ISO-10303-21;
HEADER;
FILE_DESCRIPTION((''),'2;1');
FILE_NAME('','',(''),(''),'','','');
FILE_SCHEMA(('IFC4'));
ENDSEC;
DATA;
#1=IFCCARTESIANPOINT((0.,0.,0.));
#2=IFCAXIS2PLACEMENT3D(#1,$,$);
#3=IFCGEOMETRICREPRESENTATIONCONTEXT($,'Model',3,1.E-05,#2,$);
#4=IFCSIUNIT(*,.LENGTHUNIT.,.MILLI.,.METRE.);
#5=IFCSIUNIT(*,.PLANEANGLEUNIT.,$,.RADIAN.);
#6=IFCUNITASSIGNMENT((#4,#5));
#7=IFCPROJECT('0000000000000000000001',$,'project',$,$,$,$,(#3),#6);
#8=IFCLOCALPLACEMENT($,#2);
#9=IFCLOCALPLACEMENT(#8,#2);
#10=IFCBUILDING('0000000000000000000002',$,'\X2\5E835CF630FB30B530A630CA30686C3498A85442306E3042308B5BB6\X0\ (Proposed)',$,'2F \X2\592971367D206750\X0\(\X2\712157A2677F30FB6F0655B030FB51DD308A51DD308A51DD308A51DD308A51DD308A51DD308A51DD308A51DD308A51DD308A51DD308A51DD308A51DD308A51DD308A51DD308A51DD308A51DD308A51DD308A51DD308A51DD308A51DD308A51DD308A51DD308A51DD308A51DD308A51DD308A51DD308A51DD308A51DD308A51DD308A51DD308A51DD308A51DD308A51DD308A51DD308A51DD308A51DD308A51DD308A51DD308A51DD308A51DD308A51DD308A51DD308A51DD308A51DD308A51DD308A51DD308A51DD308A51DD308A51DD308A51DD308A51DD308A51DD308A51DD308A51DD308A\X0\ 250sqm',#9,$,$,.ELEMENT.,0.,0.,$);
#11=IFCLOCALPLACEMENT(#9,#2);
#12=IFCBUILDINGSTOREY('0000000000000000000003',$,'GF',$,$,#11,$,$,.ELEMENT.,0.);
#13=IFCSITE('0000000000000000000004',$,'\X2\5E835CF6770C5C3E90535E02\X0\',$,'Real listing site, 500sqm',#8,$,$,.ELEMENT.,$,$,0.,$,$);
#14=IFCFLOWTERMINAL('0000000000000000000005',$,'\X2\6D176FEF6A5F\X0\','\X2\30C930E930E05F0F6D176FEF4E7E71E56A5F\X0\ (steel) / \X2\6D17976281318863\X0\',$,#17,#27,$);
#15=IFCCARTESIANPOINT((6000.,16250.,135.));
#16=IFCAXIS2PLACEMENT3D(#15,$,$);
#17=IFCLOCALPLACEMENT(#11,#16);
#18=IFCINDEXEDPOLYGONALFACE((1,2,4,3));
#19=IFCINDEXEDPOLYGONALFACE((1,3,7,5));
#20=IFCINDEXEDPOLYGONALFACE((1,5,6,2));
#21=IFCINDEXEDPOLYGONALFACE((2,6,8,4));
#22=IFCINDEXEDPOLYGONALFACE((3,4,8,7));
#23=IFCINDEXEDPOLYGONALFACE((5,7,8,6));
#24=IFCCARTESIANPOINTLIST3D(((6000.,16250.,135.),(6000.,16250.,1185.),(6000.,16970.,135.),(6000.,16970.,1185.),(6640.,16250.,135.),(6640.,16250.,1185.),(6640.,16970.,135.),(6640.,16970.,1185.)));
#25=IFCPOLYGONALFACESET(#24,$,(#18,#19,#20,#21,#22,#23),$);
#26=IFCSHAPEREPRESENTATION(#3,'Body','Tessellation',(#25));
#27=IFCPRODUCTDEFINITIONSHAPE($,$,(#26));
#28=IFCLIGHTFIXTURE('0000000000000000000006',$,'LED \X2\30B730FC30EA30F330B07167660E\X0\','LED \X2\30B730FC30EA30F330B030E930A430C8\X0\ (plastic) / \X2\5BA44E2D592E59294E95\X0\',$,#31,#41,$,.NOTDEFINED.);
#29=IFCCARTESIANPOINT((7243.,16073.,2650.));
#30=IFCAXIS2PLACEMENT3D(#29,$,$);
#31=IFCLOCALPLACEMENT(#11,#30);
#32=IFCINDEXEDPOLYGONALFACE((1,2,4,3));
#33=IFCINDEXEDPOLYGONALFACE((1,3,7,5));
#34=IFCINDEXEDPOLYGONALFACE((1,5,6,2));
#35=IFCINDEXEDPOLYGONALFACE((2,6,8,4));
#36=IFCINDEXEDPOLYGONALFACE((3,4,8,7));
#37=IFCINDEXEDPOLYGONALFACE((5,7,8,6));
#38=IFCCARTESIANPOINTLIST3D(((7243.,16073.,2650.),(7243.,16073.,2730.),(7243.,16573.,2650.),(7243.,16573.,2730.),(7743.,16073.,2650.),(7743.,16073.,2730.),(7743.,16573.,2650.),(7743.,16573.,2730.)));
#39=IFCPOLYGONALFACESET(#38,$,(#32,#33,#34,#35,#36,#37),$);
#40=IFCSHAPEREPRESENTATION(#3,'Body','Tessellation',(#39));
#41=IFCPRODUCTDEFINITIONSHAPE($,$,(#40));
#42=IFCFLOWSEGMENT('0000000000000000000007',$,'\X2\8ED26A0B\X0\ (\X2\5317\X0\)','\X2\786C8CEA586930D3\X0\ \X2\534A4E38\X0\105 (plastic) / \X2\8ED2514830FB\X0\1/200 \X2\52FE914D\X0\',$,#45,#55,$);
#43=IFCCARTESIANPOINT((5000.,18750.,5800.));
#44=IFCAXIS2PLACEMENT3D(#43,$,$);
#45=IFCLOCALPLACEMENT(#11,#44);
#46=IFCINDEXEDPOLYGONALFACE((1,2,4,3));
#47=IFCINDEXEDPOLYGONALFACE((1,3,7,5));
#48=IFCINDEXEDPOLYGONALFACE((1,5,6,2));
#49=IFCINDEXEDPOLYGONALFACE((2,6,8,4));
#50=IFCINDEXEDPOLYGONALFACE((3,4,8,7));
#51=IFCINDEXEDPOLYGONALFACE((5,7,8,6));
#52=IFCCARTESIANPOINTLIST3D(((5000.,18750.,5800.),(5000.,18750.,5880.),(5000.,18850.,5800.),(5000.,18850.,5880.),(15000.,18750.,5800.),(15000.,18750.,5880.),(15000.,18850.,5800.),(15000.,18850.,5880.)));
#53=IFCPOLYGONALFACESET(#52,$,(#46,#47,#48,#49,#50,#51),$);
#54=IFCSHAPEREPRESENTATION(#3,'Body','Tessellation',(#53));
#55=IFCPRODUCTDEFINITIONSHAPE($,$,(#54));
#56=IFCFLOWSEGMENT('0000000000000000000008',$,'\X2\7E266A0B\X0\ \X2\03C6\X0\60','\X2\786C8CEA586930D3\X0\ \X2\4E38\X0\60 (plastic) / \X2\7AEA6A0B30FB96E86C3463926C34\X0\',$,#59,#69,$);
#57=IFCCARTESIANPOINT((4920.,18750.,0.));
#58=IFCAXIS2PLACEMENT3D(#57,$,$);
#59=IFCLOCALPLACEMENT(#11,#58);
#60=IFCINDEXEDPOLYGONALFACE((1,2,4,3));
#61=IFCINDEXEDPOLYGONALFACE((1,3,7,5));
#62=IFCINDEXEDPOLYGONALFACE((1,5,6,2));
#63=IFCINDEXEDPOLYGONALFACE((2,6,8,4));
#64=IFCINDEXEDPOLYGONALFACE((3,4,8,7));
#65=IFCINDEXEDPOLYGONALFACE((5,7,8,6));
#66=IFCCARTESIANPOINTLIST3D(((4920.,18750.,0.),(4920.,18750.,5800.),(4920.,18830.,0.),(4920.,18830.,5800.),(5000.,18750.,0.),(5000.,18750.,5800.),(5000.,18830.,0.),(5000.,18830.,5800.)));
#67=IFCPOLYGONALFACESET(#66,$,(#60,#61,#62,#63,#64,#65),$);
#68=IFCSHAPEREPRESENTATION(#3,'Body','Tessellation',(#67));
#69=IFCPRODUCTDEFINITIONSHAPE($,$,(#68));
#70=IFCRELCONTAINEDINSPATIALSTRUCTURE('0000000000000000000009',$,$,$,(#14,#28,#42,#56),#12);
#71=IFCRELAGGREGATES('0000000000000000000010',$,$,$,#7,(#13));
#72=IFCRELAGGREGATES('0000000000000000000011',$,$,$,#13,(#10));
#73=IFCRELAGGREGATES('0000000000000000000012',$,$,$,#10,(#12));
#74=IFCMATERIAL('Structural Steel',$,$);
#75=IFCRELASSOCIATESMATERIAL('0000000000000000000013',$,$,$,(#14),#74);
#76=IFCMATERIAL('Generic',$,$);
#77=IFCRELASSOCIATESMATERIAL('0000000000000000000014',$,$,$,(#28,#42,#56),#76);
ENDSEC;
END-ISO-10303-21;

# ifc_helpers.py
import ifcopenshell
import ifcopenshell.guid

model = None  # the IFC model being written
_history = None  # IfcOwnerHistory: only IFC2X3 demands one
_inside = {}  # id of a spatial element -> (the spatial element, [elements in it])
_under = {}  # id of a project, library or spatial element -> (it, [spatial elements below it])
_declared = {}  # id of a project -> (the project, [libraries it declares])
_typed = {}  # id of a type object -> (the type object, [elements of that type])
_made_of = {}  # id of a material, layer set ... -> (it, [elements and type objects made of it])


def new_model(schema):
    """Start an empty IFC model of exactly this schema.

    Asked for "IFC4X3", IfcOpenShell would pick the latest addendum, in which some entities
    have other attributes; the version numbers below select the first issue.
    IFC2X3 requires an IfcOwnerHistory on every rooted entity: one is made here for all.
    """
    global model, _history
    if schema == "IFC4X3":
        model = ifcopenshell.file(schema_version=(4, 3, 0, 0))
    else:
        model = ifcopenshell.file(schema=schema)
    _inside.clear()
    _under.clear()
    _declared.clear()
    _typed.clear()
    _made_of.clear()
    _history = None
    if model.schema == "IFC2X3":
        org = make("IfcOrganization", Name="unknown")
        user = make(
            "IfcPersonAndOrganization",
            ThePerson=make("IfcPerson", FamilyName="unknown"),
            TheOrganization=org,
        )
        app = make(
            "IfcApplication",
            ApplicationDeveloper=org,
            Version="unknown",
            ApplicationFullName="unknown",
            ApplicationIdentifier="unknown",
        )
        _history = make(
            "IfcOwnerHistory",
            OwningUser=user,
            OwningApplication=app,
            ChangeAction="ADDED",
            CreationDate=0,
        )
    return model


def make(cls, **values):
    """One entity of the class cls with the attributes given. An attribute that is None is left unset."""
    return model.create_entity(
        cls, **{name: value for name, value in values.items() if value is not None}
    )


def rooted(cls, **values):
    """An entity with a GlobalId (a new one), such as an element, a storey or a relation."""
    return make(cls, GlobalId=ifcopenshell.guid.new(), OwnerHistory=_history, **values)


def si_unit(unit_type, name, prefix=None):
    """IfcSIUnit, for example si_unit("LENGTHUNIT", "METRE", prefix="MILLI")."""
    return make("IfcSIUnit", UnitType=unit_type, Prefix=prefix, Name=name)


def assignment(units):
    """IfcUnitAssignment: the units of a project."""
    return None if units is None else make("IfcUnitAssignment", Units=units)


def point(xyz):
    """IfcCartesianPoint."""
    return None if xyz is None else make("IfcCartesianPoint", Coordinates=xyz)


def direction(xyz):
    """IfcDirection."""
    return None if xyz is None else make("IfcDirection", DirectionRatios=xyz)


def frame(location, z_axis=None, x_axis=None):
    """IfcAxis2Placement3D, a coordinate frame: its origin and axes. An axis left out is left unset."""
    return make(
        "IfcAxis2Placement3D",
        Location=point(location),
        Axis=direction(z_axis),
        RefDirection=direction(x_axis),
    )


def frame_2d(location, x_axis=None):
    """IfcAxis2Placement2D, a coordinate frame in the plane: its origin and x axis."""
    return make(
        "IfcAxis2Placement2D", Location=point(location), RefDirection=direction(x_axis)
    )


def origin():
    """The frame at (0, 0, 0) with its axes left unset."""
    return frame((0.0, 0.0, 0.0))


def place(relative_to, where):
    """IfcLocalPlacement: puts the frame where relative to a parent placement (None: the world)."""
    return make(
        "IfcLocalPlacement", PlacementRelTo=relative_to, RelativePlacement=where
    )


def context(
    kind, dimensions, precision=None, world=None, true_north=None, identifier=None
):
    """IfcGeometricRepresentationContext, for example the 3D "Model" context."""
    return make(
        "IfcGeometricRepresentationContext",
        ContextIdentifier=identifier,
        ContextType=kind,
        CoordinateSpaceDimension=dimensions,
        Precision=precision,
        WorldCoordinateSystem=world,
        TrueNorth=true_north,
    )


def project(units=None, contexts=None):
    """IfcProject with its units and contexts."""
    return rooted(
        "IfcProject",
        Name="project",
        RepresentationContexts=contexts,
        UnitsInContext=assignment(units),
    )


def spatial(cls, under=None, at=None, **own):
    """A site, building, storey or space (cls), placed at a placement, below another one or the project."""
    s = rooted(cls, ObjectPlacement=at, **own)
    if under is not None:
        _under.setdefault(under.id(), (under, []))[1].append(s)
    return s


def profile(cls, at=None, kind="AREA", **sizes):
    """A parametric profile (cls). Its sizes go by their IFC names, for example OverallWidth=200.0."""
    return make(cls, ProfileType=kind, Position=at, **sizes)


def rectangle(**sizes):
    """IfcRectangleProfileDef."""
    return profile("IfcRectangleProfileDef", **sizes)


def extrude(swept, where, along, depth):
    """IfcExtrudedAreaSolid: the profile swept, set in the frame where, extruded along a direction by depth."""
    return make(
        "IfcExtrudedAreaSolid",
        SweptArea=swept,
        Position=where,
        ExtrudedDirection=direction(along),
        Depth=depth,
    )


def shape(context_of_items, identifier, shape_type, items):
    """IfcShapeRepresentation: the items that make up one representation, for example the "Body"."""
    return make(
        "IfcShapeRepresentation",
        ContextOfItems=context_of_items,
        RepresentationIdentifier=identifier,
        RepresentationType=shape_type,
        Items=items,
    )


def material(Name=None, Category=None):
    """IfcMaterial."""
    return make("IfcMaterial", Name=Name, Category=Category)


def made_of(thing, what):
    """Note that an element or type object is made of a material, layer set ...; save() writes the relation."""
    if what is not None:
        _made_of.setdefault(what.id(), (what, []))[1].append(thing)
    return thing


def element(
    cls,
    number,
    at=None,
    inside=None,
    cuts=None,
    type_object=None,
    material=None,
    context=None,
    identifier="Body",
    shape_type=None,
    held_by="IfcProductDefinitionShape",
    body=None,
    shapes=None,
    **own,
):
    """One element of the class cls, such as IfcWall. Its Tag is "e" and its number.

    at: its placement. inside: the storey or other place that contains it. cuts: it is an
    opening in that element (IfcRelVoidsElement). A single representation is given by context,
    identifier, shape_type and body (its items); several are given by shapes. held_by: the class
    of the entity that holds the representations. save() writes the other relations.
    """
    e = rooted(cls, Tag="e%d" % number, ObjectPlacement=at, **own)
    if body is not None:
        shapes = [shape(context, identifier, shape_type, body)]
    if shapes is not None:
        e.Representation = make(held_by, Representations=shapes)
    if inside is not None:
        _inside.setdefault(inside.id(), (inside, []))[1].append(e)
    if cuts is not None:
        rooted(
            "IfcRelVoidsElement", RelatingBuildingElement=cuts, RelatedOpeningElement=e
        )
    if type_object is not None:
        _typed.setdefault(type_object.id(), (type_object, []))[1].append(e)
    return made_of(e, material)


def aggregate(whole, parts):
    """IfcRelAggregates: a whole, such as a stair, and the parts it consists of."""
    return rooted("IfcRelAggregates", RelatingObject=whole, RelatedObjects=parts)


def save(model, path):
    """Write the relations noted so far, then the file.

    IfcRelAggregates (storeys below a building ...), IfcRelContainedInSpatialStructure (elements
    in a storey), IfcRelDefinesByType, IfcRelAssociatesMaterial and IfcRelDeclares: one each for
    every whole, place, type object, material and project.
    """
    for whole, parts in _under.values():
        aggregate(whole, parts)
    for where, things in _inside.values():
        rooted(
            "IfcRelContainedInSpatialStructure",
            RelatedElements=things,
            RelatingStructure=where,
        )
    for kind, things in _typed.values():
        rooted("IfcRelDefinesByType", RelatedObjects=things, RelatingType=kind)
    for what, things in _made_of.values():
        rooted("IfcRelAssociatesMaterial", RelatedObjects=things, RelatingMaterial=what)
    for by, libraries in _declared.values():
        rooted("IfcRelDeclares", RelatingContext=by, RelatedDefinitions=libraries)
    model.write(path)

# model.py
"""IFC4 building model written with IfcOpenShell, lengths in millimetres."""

from ifc_helpers import new_model, si_unit, frame, frame_2d, origin, place, context, project, spatial, rectangle, extrude, material, element, save


model = new_model("IFC4")

# Units and contexts
model_context = context("Model", 3, precision=1e-05, world=origin())
ifc_project = project(units=[si_unit("LENGTHUNIT", "METRE", prefix="MILLI"), si_unit("PLANEANGLEUNIT", "RADIAN")], contexts=[model_context])

# Site, building, storey
site_placement = place(None, origin())
site = spatial("IfcSite", under=ifc_project, at=site_placement, Name="広島県尾道市", ObjectType="Real listing site, 500sqm", CompositionType="ELEMENT", RefElevation=0.0)
building_placement = place(site_placement, origin())
building = spatial("IfcBuilding", under=site, at=building_placement, Name="広島・サウナと水風呂のある家 (Proposed)", ObjectType="2F 天然素材(無垢板・漆喰・凝り凝り凝り凝り凝り凝り凝り凝り凝り凝り凝り凝り凝り凝り凝り凝り凝り凝り凝り凝り凝り凝り凝り凝り凝り凝り凝り凝り凝り凝り凝り凝り凝り凝り凝り凝り凝り凝り凝り凝り凝り凝り凝り凝り凝り凝り凝り凝り凝り凝り凝り凝り凝り凝り 250sqm", CompositionType="ELEMENT", ElevationOfRefHeight=0.0, ElevationOfTerrain=0.0)
storey_placement = place(building_placement, origin())
storey = spatial("IfcBuildingStorey", under=building, at=storey_placement, Name="GF", CompositionType="ELEMENT", Elevation=0.0)

# Flow terminal
ifc_material_1 = material(Name="Structural Steel")
flow_terminal_placement = place(storey_placement, frame((6000.0, 16250.0, 135.0)))
element("IfcFlowTerminal", 1, at=flow_terminal_placement, inside=storey, material=ifc_material_1, Name="洗濯機", Description="ドラム式洗濯乾燥機 (steel) / 洗面脱衣", context=model_context, shape_type="SweptSolid", body=[
    extrude(rectangle(XDim=640.0, YDim=720.0, at=frame_2d((320.0, 360.0))), frame((6000.0, 16250.0, 135.0)), (0.0, 0.0, 1.0), 1050.0),
])

# Light fixture
ifc_material_2 = material(Name="Generic")
light_fixture_placement = place(storey_placement, frame((7243.0, 16073.0, 2650.0)))
element("IfcLightFixture", 2, at=light_fixture_placement, inside=storey, material=ifc_material_2, Name="LED シーリング照明", Description="LED シーリングライト (plastic) / 室中央天井", PredefinedType="NOTDEFINED", context=model_context, shape_type="SweptSolid", body=[
    extrude(rectangle(XDim=500.0, YDim=500.0, at=frame_2d((250.0, 250.0))), frame((7243.0, 16073.0, 2650.0)), (0.0, 0.0, 1.0), 80.0),
])

# Flow segments
flow_segment_1_placement = place(storey_placement, frame((5000.0, 18750.0, 5800.0)))
element("IfcFlowSegment", 3, at=flow_segment_1_placement, inside=storey, material=ifc_material_2, Name="軒樋 (北)", Description="硬質塩ビ 半丸105 (plastic) / 軒先・1/200 勾配", context=model_context, shape_type="SweptSolid", body=[
    extrude(rectangle(XDim=10000.0, YDim=100.0, at=frame_2d((5000.0, 50.0))), frame((5000.0, 18750.0, 5800.0)), (0.0, 0.0, 1.0), 80.0),
])
flow_segment_2_placement = place(storey_placement, frame((4920.0, 18750.0, 0.0)))
element("IfcFlowSegment", 4, at=flow_segment_2_placement, inside=storey, material=ifc_material_2, Name="縦樋 φ60", Description="硬質塩ビ 丸60 (plastic) / 竪樋・雨水排水", context=model_context, shape_type="SweptSolid", body=[
    extrude(rectangle(XDim=80.0, YDim=80.0, at=frame_2d((40.0, 40.0))), frame((4920.0, 18750.0, 0.0)), (0.0, 0.0, 1.0), 5800.0),
])

save(model, "model.ifc")
